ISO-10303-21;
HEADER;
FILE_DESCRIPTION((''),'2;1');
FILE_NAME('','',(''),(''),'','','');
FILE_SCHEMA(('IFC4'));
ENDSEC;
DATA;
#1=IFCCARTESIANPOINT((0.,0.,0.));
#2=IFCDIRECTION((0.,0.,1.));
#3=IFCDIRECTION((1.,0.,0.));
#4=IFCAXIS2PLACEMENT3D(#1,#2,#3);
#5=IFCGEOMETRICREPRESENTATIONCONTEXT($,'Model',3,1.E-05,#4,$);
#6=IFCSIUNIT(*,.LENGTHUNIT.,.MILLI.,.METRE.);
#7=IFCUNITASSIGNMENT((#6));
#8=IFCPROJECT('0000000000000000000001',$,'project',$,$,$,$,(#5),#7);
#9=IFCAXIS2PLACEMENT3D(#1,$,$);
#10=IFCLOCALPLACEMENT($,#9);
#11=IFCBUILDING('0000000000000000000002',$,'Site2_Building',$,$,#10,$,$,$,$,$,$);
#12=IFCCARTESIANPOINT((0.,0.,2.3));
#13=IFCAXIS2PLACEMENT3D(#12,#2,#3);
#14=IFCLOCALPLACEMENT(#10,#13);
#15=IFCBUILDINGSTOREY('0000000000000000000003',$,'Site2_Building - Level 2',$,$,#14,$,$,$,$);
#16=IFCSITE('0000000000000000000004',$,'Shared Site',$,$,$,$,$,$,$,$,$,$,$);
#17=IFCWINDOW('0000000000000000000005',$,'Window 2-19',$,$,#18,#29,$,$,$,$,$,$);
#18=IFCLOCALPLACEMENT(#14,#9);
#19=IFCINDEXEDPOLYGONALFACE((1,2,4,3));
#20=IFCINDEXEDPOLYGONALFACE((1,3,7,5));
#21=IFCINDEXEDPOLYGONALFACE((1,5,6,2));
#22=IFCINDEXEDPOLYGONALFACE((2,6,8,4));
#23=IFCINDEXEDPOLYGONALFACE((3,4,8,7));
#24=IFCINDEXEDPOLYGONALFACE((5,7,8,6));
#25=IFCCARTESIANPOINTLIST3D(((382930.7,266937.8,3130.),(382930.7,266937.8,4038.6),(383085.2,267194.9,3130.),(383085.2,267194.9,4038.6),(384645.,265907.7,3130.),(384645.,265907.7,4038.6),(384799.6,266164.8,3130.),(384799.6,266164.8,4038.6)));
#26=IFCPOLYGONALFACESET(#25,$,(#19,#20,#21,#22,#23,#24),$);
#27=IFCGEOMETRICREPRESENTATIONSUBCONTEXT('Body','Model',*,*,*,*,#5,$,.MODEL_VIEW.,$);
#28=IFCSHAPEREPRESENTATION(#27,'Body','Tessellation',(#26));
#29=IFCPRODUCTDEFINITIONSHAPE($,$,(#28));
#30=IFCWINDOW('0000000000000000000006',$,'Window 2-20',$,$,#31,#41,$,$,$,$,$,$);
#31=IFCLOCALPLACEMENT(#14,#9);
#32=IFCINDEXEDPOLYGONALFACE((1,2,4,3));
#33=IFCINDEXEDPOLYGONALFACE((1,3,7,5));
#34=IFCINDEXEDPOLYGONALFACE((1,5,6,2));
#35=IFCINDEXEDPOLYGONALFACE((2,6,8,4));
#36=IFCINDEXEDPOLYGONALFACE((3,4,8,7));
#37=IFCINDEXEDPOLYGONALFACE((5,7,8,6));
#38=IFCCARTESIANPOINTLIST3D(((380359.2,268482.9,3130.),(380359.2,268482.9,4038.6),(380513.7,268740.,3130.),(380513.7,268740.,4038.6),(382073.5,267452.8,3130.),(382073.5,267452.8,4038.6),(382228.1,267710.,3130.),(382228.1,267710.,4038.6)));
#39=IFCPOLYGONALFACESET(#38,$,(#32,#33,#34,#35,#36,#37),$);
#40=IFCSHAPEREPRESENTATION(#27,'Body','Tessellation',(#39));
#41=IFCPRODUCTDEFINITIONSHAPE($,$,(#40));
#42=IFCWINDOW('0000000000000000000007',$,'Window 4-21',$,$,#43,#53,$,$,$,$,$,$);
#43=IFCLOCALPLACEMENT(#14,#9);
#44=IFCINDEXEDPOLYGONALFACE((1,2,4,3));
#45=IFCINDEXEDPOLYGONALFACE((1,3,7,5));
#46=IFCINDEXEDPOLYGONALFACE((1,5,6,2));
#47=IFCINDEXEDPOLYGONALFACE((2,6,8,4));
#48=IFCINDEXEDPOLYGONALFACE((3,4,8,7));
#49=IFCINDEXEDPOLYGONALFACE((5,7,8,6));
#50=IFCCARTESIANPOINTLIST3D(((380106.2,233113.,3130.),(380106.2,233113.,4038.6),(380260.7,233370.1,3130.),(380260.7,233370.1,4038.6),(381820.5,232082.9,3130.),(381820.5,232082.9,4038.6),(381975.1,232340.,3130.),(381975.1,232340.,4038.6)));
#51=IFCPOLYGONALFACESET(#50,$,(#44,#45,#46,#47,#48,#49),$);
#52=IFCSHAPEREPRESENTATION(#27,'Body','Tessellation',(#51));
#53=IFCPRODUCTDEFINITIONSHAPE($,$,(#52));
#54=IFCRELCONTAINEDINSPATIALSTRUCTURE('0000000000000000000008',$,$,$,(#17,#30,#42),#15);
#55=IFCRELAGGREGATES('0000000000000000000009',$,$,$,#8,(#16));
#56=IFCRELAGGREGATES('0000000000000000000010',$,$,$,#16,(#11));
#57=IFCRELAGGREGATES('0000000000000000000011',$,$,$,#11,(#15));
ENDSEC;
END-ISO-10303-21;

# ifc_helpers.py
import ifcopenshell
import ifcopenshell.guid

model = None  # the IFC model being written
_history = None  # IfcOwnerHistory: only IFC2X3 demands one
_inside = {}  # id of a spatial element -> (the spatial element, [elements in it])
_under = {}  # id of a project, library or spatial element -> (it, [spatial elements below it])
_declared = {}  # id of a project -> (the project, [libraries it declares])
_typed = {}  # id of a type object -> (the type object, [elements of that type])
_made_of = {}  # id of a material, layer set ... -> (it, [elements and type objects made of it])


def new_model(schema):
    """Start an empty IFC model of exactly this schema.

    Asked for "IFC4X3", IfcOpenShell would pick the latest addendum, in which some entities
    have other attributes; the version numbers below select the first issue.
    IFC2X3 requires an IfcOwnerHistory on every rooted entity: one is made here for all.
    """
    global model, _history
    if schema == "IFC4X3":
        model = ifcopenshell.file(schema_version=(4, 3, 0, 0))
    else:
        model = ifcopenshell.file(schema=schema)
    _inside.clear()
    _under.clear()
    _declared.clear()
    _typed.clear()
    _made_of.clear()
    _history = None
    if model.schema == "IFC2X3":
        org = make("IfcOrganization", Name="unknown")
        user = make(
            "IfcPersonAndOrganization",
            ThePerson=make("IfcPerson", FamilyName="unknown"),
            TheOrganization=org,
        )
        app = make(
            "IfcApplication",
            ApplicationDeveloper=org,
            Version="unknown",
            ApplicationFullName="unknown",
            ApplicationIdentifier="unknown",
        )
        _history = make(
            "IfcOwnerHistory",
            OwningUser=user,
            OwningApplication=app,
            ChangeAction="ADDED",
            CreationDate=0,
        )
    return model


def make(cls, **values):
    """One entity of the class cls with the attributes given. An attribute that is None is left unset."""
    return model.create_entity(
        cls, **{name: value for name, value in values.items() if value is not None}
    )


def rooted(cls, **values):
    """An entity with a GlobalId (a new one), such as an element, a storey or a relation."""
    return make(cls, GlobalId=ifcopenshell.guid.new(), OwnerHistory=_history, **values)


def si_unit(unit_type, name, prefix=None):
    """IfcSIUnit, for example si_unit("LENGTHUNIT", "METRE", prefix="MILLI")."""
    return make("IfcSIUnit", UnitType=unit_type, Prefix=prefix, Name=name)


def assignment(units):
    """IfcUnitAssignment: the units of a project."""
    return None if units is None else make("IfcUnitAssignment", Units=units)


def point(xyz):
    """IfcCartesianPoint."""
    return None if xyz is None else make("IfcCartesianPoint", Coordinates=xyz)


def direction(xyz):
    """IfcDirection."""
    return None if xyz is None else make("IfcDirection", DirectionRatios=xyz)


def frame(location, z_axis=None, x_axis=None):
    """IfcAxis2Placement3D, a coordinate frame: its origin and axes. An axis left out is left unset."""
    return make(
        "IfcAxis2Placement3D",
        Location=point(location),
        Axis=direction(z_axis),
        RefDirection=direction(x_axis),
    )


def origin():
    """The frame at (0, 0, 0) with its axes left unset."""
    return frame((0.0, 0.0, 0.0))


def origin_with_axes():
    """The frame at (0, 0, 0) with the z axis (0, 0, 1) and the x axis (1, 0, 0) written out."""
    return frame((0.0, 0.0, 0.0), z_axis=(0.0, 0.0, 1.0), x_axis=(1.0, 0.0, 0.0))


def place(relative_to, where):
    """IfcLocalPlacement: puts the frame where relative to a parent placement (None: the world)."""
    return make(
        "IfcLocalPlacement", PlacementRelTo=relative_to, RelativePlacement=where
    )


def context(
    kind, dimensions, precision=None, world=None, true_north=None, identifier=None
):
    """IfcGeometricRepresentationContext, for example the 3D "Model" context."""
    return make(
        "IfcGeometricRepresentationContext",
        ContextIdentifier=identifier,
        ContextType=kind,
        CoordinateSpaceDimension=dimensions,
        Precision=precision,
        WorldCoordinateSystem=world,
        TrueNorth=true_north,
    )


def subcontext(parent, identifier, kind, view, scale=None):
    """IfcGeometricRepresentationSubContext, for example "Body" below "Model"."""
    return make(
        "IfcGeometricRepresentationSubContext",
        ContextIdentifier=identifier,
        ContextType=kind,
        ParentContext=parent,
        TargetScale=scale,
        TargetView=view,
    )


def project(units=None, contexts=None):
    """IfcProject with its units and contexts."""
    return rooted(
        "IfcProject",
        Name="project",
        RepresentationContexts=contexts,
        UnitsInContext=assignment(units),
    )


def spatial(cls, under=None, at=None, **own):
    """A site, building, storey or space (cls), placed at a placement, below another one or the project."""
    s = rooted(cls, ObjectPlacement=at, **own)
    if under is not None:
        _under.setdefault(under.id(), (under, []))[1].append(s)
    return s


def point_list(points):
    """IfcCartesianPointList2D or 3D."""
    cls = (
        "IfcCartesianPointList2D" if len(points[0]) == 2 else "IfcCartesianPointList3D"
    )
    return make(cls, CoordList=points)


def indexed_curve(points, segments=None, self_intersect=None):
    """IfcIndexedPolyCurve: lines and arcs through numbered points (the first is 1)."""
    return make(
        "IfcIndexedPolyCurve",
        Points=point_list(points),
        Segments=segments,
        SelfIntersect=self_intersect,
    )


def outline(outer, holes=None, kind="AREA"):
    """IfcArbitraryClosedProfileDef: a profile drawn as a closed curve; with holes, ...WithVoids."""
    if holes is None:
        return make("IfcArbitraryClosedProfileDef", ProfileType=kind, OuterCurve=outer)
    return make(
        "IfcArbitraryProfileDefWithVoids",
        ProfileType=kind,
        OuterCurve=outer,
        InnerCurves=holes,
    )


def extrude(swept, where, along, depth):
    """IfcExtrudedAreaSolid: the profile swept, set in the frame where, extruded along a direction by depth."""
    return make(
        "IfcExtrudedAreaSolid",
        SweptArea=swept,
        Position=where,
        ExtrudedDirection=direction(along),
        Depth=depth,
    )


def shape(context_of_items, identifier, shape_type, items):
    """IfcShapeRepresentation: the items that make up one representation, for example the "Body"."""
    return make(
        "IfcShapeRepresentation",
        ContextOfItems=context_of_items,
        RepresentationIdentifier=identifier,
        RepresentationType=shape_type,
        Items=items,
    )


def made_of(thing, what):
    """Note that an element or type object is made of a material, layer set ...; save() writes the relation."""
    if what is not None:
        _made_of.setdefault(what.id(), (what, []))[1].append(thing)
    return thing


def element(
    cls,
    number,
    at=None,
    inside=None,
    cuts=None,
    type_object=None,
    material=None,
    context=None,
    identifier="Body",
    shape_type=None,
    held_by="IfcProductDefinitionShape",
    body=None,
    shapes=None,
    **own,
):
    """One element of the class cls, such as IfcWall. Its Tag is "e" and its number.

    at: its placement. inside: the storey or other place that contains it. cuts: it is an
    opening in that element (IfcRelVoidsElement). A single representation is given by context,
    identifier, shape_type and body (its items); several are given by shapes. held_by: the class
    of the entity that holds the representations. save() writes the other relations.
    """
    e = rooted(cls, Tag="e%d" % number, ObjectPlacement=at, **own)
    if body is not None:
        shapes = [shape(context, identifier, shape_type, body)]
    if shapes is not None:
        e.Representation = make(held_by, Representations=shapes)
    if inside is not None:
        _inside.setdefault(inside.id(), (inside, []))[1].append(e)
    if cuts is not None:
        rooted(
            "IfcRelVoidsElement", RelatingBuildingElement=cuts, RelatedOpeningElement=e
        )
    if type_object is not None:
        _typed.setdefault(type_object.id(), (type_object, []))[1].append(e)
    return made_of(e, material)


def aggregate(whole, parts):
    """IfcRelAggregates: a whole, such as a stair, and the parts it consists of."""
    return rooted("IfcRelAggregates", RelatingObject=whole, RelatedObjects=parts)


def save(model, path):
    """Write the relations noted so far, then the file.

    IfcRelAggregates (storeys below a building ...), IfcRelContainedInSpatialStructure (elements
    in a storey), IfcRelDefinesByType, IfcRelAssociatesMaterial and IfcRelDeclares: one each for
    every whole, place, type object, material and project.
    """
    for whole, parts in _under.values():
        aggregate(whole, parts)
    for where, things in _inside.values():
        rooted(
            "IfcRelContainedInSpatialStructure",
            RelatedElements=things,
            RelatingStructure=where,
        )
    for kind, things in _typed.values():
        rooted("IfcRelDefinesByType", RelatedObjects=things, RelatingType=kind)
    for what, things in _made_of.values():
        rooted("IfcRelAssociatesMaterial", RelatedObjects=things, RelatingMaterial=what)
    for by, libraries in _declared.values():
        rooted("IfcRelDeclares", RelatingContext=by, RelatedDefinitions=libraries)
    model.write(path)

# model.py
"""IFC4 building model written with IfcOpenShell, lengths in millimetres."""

from ifc_helpers import new_model, si_unit, frame, origin, origin_with_axes, place, context, subcontext, project, spatial, indexed_curve, outline, extrude, element, save


model = new_model("IFC4")

# Units and contexts
model_context = context("Model", 3, precision=1e-05, world=origin_with_axes())
body_context = subcontext(model_context, "Body", "Model", "MODEL_VIEW")
ifc_project = project(units=[si_unit("LENGTHUNIT", "METRE", prefix="MILLI")], contexts=[model_context])

# Site, building, storey
site = spatial("IfcSite", under=ifc_project, Name="Shared Site")
building_placement = place(None, origin())
building = spatial("IfcBuilding", under=site, at=building_placement, Name="Site2_Building")
storey_placement = place(building_placement, frame((0.0, 0.0, 2.3), z_axis=(0.0, 0.0, 1.0), x_axis=(1.0, 0.0, 0.0)))
storey = spatial("IfcBuildingStorey", under=building, at=storey_placement, Name="Site2_Building - Level 2")

# Windows
for number, where, z_axis, x_axis, name in (
    (1, (384799.6, 266164.8, 3130.0), (0.0, 0.0, 1.0), (-0.857167, 0.515038, 0.0), "Window 2-19"),
    (2, (382228.1, 267710.0, 3130.0), (0.0, 0.0, 1.0), (-0.857167, 0.515038, 0.0), "Window 2-20"),
    (3, (380106.2, 233113.0, 3130.0), (0.0, 0.0, 1.0), (0.857167, -0.515038, 0.0), "Window 4-21"),
):
    element("IfcWindow", number, at=place(storey_placement, frame(where, z_axis=z_axis, x_axis=x_axis)), inside=storey, Name=name, context=body_context, shape_type="SweptSolid", body=[
        extrude(outline(indexed_curve([(0.0, 0.0), (0.0, 300.0), (2000.0, 300.0), (2000.0, 0.0), (0.0, 0.0)], self_intersect=False)), origin_with_axes(), (0.0, 0.0, 1.0), 908.6),
    ])

save(model, "model.ifc")
